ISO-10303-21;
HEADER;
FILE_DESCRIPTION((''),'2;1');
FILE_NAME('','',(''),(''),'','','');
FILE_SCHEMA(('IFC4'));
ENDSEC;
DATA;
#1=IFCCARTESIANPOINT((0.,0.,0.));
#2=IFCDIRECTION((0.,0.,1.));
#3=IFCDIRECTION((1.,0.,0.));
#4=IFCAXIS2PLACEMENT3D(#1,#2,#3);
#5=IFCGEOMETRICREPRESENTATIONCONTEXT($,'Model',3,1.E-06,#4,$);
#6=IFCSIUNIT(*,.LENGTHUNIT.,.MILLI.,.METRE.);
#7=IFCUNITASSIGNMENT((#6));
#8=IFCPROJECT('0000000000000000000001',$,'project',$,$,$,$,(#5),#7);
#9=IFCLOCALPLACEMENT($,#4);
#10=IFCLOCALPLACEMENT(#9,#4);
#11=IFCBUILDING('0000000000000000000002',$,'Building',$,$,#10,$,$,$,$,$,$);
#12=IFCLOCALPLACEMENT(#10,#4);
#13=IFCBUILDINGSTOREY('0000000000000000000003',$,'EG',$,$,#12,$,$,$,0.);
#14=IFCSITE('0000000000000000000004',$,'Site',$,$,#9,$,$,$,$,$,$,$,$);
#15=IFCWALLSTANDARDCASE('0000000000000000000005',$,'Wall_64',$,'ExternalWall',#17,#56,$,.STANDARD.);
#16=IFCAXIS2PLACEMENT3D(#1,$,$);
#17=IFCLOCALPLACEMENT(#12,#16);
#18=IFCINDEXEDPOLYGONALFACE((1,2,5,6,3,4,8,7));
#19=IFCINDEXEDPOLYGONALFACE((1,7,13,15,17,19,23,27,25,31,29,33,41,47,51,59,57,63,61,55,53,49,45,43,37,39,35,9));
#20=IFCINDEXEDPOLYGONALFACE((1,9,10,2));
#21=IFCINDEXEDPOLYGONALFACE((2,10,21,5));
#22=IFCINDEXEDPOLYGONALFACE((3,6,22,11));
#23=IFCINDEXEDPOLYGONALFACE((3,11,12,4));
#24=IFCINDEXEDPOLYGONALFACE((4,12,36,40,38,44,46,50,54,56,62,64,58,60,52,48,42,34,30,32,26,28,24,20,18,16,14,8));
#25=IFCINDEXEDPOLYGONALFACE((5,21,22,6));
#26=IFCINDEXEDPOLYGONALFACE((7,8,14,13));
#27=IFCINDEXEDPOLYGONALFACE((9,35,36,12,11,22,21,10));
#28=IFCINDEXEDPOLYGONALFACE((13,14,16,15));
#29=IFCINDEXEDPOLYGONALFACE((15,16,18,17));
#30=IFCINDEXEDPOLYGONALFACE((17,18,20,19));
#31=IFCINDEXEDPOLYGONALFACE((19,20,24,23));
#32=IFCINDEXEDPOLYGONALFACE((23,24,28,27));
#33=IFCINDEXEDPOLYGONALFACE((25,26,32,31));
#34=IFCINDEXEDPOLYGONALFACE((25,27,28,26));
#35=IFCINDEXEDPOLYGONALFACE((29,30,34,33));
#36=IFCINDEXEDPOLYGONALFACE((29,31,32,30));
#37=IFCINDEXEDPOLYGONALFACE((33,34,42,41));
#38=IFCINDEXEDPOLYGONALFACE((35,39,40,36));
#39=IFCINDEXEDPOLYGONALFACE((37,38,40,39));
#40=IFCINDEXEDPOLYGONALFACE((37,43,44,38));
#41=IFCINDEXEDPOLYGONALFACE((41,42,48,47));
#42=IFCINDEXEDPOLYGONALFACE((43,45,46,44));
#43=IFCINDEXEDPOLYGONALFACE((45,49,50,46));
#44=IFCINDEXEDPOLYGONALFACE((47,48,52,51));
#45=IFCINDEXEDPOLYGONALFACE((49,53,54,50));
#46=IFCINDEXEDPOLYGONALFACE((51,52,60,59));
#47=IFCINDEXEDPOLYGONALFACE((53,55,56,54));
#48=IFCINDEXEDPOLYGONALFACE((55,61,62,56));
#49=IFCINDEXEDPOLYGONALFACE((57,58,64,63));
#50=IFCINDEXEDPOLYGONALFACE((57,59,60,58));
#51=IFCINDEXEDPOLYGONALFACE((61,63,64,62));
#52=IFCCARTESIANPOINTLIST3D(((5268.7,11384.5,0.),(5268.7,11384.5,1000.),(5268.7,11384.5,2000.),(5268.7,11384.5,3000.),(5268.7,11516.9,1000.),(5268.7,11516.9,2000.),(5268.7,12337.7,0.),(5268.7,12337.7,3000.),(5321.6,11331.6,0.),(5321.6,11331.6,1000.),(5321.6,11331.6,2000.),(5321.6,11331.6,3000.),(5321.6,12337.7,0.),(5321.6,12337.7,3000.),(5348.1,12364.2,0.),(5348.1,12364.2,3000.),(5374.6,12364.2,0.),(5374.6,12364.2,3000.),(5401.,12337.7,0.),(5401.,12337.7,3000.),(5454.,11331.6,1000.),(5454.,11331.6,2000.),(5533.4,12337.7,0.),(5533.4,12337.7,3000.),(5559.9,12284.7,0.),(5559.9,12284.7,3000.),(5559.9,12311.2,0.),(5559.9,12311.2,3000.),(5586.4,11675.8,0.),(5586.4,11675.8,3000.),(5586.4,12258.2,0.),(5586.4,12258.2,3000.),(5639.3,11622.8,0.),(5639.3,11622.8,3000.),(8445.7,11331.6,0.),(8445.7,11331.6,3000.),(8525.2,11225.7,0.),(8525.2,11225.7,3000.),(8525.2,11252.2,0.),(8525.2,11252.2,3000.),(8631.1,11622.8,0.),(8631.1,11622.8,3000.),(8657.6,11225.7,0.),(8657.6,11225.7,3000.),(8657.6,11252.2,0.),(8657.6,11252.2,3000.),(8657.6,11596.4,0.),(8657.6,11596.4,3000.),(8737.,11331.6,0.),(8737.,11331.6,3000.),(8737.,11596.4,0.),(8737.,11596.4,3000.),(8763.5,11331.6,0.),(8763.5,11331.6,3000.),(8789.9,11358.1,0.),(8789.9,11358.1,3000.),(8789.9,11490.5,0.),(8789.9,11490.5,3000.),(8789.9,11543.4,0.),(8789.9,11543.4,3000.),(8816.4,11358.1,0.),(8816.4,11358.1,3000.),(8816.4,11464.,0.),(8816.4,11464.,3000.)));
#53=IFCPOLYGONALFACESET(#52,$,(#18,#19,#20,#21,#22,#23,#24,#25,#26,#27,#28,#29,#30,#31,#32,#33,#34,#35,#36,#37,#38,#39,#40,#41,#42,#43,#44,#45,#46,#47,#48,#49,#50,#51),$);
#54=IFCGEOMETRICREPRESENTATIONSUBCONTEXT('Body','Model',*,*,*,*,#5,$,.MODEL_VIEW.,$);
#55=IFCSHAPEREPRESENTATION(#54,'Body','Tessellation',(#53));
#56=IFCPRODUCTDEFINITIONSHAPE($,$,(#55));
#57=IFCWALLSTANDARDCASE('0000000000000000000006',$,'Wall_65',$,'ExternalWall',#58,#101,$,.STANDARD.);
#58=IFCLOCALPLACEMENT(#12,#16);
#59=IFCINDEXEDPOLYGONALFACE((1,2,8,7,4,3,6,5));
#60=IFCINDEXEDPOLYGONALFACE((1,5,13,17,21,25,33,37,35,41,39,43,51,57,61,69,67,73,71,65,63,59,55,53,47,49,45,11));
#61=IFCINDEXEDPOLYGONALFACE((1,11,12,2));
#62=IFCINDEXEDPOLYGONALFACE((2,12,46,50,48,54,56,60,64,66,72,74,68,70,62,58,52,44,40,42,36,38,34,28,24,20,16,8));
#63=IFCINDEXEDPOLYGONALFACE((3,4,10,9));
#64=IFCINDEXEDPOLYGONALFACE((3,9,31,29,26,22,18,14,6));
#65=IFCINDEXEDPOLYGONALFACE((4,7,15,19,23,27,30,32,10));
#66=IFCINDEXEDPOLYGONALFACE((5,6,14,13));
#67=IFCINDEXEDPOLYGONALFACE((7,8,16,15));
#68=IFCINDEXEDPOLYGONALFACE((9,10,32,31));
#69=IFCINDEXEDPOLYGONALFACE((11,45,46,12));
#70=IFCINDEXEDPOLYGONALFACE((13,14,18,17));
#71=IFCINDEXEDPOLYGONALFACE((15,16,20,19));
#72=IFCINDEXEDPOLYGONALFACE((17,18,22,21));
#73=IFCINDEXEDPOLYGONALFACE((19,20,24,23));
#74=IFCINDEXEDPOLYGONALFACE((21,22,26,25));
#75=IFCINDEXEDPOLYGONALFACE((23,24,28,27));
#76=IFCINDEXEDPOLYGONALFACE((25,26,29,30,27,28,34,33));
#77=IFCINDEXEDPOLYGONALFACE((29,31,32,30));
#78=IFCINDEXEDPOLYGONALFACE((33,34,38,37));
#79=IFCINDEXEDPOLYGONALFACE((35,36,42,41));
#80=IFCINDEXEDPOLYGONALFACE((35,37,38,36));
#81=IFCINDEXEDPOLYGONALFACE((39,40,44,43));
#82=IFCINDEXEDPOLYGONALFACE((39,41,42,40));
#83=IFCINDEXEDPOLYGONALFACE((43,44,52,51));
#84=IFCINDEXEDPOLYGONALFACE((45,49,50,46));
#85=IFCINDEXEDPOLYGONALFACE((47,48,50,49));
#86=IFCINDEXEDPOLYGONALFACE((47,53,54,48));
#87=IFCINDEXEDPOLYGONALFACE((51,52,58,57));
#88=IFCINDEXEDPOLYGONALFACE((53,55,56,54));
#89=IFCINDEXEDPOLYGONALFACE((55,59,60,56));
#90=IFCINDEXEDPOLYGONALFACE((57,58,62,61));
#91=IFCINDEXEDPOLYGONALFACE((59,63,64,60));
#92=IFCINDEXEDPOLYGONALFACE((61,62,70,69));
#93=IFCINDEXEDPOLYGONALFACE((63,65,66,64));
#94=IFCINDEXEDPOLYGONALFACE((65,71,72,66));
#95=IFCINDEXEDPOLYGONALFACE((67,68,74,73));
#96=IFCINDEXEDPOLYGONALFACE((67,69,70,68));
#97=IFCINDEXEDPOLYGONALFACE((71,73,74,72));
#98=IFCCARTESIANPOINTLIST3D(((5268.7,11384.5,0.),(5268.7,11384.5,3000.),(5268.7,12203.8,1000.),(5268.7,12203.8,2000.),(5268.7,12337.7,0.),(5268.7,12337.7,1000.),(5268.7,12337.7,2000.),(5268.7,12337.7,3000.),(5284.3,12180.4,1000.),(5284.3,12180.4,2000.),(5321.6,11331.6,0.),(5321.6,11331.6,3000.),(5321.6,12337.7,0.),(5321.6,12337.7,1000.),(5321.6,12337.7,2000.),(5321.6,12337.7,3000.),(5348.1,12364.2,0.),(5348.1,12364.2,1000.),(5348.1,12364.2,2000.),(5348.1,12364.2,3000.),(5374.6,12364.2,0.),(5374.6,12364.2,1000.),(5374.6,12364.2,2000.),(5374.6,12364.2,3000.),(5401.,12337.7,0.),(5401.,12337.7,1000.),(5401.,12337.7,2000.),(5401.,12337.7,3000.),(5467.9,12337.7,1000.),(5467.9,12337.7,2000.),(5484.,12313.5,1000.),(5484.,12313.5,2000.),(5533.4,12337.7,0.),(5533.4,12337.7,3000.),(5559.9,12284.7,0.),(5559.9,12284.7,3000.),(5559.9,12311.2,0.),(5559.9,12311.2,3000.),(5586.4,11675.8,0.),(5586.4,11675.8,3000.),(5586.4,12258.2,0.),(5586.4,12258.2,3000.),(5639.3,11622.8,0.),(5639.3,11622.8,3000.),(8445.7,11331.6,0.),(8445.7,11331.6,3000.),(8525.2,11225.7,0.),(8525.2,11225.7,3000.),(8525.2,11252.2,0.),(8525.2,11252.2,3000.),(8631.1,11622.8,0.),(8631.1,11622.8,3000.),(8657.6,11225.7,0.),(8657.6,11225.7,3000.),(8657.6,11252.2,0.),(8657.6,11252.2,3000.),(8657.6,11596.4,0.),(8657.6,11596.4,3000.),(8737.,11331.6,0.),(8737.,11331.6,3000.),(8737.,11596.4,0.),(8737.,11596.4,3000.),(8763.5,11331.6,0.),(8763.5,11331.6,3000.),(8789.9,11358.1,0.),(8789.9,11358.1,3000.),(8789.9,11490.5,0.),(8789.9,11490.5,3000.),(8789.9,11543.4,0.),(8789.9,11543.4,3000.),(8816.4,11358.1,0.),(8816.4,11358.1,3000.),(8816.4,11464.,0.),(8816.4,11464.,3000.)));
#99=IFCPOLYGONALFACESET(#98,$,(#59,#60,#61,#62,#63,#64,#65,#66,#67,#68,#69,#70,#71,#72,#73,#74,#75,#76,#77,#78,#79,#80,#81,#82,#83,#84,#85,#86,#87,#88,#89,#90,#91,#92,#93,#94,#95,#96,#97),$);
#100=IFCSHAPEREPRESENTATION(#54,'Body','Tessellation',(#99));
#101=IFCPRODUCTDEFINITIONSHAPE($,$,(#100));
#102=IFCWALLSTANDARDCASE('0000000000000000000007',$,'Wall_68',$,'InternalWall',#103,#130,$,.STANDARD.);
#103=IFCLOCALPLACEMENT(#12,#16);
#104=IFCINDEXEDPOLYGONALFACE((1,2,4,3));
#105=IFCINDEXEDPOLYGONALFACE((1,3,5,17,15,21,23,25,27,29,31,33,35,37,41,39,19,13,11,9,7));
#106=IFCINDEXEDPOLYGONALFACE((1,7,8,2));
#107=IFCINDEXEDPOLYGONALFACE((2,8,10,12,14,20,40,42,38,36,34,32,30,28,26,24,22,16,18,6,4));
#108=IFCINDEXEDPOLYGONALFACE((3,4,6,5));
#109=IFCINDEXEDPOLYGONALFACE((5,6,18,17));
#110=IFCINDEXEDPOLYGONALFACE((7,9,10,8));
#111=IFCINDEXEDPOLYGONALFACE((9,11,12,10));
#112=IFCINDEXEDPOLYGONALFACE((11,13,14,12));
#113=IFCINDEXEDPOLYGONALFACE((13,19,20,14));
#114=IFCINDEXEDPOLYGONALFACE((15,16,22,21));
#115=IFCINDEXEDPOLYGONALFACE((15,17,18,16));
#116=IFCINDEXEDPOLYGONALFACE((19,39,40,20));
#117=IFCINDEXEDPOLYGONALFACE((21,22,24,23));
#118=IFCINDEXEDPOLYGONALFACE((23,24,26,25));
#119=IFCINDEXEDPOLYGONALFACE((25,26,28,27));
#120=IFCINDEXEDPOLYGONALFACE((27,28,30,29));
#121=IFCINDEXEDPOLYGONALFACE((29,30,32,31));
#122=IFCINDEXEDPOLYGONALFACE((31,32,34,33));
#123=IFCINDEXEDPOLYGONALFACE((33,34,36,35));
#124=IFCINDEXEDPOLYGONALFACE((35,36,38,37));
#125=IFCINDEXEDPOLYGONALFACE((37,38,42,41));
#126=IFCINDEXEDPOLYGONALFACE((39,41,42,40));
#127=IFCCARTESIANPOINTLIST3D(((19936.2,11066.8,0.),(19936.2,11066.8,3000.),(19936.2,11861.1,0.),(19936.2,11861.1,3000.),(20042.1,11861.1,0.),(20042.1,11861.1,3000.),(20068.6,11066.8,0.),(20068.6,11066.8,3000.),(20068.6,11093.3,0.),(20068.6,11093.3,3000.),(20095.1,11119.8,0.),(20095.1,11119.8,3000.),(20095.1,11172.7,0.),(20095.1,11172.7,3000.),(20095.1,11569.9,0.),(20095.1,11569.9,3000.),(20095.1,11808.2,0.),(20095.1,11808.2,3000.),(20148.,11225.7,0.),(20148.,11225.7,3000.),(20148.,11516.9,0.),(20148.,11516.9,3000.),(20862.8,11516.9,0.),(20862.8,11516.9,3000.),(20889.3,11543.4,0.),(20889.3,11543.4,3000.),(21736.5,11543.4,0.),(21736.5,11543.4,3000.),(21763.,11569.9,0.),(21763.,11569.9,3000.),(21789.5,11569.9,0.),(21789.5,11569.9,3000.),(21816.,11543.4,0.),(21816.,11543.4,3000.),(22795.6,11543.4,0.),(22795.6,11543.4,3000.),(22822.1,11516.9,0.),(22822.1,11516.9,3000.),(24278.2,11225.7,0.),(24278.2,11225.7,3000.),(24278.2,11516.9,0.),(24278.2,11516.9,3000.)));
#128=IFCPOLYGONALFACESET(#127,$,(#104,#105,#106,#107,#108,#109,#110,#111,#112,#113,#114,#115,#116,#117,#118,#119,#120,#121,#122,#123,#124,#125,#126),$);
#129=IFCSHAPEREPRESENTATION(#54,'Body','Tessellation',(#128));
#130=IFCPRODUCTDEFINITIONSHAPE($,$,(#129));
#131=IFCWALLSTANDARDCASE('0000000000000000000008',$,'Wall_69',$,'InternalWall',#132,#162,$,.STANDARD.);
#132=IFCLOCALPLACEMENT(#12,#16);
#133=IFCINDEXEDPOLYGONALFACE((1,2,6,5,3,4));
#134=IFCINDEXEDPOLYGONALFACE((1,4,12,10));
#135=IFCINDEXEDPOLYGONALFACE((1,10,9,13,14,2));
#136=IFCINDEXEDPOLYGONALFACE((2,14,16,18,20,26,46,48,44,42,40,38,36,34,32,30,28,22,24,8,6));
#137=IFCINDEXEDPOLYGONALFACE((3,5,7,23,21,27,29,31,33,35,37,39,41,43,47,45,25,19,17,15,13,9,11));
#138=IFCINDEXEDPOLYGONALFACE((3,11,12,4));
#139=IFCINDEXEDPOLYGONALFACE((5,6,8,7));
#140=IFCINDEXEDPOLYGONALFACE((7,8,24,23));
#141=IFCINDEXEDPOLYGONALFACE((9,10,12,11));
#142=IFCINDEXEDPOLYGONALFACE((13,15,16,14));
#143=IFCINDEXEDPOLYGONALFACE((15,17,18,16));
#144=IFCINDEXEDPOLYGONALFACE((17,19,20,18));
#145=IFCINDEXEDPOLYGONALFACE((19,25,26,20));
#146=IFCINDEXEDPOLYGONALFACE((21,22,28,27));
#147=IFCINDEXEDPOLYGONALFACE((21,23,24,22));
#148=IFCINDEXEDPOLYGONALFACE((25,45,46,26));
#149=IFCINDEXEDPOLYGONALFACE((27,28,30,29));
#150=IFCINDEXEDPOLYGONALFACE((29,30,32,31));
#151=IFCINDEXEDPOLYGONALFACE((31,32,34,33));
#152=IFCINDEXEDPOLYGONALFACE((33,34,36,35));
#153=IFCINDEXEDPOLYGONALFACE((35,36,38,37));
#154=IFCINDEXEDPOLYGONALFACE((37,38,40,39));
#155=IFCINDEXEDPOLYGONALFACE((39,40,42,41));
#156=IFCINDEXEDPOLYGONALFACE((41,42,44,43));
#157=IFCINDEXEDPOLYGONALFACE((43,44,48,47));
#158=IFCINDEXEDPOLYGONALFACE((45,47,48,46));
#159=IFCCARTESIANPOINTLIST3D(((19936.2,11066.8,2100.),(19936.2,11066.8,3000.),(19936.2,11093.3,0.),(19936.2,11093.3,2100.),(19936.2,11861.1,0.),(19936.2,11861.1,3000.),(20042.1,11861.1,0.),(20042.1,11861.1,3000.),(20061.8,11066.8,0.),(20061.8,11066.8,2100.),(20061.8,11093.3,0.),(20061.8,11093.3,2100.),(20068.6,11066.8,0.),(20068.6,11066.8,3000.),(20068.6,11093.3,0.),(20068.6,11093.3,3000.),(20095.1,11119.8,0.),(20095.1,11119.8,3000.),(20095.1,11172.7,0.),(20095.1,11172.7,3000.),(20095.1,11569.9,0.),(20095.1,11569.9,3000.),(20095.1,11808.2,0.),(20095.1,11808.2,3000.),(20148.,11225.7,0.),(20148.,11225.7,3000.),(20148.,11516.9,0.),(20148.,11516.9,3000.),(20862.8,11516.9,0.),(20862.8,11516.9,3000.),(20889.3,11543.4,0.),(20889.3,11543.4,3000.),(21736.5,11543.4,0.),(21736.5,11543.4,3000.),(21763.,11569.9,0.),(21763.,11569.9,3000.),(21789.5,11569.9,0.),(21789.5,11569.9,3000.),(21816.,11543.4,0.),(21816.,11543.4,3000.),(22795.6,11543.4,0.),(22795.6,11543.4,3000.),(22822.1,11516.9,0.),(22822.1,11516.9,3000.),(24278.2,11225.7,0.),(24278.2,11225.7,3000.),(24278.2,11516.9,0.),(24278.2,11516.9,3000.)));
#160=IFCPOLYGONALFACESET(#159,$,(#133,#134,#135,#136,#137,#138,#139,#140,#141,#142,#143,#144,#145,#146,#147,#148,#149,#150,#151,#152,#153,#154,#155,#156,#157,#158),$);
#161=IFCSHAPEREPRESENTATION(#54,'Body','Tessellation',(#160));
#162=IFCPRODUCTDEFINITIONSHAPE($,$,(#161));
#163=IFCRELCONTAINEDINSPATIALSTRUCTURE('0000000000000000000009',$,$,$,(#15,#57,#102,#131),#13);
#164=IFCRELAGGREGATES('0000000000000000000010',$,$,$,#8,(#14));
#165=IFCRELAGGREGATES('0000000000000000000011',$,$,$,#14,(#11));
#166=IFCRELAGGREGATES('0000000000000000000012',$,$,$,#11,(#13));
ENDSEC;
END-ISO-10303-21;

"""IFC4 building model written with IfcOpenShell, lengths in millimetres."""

from ifc_helpers import new_model, si_unit, frame, origin_with_axes, place, context, subcontext, project, spatial, polyline, rectangle, outline, extrude, element, save


model = new_model("IFC4")

# Units and contexts
model_context = context("Model", 3, precision=1e-06, world=origin_with_axes())
body_context = subcontext(model_context, "Body", "Model", "MODEL_VIEW")
ifc_project = project(units=[si_unit("LENGTHUNIT", "METRE", prefix="MILLI")], contexts=[model_context])

# Site, building, storey
site_placement = place(None, origin_with_axes())
site = spatial("IfcSite", under=ifc_project, at=site_placement, Name="Site")
building_placement = place(site_placement, origin_with_axes())
building = spatial("IfcBuilding", under=site, at=building_placement, Name="Building")
storey_placement = place(building_placement, origin_with_axes())
storey = spatial("IfcBuildingStorey", under=building, at=storey_placement, Name="EG", Elevation=0.0)

# Walls, openings
wall_1_placement = place(storey_placement, origin_with_axes())
wall_1 = element("IfcWallStandardCase", 1, at=wall_1_placement, inside=storey, Name="Wall_64", ObjectType="ExternalWall", PredefinedType="STANDARD", context=body_context, shape_type="SweptSolid", body=[
    extrude(outline(polyline([(8525.2, 11225.7, 0.0), (8525.2, 11252.2, 0.0), (8445.7, 11331.6, 0.0), (5321.6, 11331.6, 0.0), (5268.7, 11384.5, 0.0), (5268.7, 12337.7, 0.0), (5321.6, 12337.7, 0.0), (5348.1, 12364.2, 0.0), (5374.6, 12364.2, 0.0), (5401.0, 12337.7, 0.0), (5533.4, 12337.7, 0.0), (5559.9, 12311.2, 0.0), (5559.9, 12284.7, 0.0), (5586.4, 12258.2, 0.0), (5586.4, 11675.8, 0.0), (5639.3, 11622.8, 0.0), (8631.1, 11622.8, 0.0), (8657.6, 11596.4, 0.0), (8737.0, 11596.4, 0.0), (8789.9, 11543.4, 0.0), (8789.9, 11490.5, 0.0), (8816.4, 11464.0, 0.0), (8816.4, 11358.1, 0.0), (8789.9, 11358.1, 0.0), (8763.5, 11331.6, 0.0), (8737.0, 11331.6, 0.0), (8657.6, 11252.2, 0.0), (8657.6, 11225.7, 0.0), (8525.2, 11225.7, 0.0)])), origin_with_axes(), (0.0, 0.0, 1.0), 3000.0),
])
opening_1_placement = place(wall_1_placement, origin_with_axes())
element("IfcOpeningElement", 2, at=opening_1_placement, inside=storey, cuts=wall_1, context=body_context, shape_type="SweptSolid", body=[
    extrude(rectangle(XDim=636.5, YDim=300.0), frame((5133.7, 11201.8, 1000.0), z_axis=(0.0, 0.0, 1.0), x_axis=(-0.707107, -0.707107, 0.0)), (0.0, 0.0, 1.0), 1000.0),
])
wall_2_placement = place(storey_placement, origin_with_axes())
wall_2 = element("IfcWallStandardCase", 3, at=wall_2_placement, inside=storey, Name="Wall_65", ObjectType="ExternalWall", PredefinedType="STANDARD", context=body_context, shape_type="SweptSolid", body=[
    extrude(outline(polyline([(8525.2, 11225.7, 0.0), (8525.2, 11252.2, 0.0), (8445.7, 11331.6, 0.0), (5321.6, 11331.6, 0.0), (5268.7, 11384.5, 0.0), (5268.7, 12337.7, 0.0), (5321.6, 12337.7, 0.0), (5348.1, 12364.2, 0.0), (5374.6, 12364.2, 0.0), (5401.0, 12337.7, 0.0), (5533.4, 12337.7, 0.0), (5559.9, 12311.2, 0.0), (5559.9, 12284.7, 0.0), (5586.4, 12258.2, 0.0), (5586.4, 11675.8, 0.0), (5639.3, 11622.8, 0.0), (8631.1, 11622.8, 0.0), (8657.6, 11596.4, 0.0), (8737.0, 11596.4, 0.0), (8789.9, 11543.4, 0.0), (8789.9, 11490.5, 0.0), (8816.4, 11464.0, 0.0), (8816.4, 11358.1, 0.0), (8789.9, 11358.1, 0.0), (8763.5, 11331.6, 0.0), (8737.0, 11331.6, 0.0), (8657.6, 11252.2, 0.0), (8657.6, 11225.7, 0.0), (8525.2, 11225.7, 0.0)])), origin_with_axes(), (0.0, 0.0, 1.0), 3000.0),
])
opening_2_placement = place(wall_2_placement, origin_with_axes())
element("IfcOpeningElement", 4, at=opening_2_placement, inside=storey, cuts=wall_2, context=body_context, shape_type="SweptSolid", body=[
    extrude(rectangle(XDim=2592.1, YDim=240.0), frame((4665.2, 13325.3, 1000.0), z_axis=(0.0, 0.0, 1.0), x_axis=(-0.5547, 0.83205, 0.0)), (0.0, 0.0, 1.0), 1000.0),
])

# Wall
wall_3_placement = place(storey_placement, origin_with_axes())
element("IfcWallStandardCase", 5, at=wall_3_placement, inside=storey, Name="Wall_68", ObjectType="InternalWall", PredefinedType="STANDARD", context=body_context, shape_type="SweptSolid", body=[
    extrude(outline(polyline([(19936.2, 11066.8, 0.0), (19936.2, 11861.1, 0.0), (20042.1, 11861.1, 0.0), (20095.1, 11808.2, 0.0), (20095.1, 11569.9, 0.0), (20148.0, 11516.9, 0.0), (20862.8, 11516.9, 0.0), (20889.3, 11543.4, 0.0), (21736.5, 11543.4, 0.0), (21763.0, 11569.9, 0.0), (21789.5, 11569.9, 0.0), (21816.0, 11543.4, 0.0), (22795.6, 11543.4, 0.0), (22822.1, 11516.9, 0.0), (24278.2, 11516.9, 0.0), (24278.2, 11225.7, 0.0), (20148.0, 11225.7, 0.0), (20095.1, 11172.7, 0.0), (20095.1, 11119.8, 0.0), (20068.6, 11093.3, 0.0), (20068.6, 11066.8, 0.0), (19936.2, 11066.8, 0.0)])), origin_with_axes(), (0.0, 0.0, 1.0), 3000.0),
])

# Wall, openings
wall_4_placement = place(storey_placement, origin_with_axes())
wall_4 = element("IfcWallStandardCase", 6, at=wall_4_placement, inside=storey, Name="Wall_69", ObjectType="InternalWall", PredefinedType="STANDARD", context=body_context, shape_type="SweptSolid", body=[
    extrude(outline(polyline([(19936.2, 11066.8, 0.0), (19936.2, 11861.1, 0.0), (20042.1, 11861.1, 0.0), (20095.1, 11808.2, 0.0), (20095.1, 11569.9, 0.0), (20148.0, 11516.9, 0.0), (20862.8, 11516.9, 0.0), (20889.3, 11543.4, 0.0), (21736.5, 11543.4, 0.0), (21763.0, 11569.9, 0.0), (21789.5, 11569.9, 0.0), (21816.0, 11543.4, 0.0), (22795.6, 11543.4, 0.0), (22822.1, 11516.9, 0.0), (24278.2, 11516.9, 0.0), (24278.2, 11225.7, 0.0), (20148.0, 11225.7, 0.0), (20095.1, 11172.7, 0.0), (20095.1, 11119.8, 0.0), (20068.6, 11093.3, 0.0), (20068.6, 11066.8, 0.0), (19936.2, 11066.8, 0.0)])), origin_with_axes(), (0.0, 0.0, 1.0), 3000.0),
])
opening_3_placement = place(wall_4_placement, origin_with_axes())
element("IfcOpeningElement", 7, at=opening_3_placement, inside=storey, cuts=wall_4, context=body_context, shape_type="SweptSolid", body=[
    extrude(rectangle(XDim=1059.0, YDim=240.0), frame((19941.8, 10563.8, 0.0), z_axis=(0.0, 0.0, 1.0), x_axis=(0.0, -1.0, 0.0)), (0.0, 0.0, 1.0), 2100.0),
])
opening_4_placement = place(wall_4_placement, origin_with_axes())
element("IfcOpeningElement", 8, at=opening_4_placement, inside=storey, cuts=wall_4, context=body_context, shape_type="SweptSolid", body=[
    extrude(rectangle(XDim=847.2, YDim=240.0), frame((19941.8, 12284.7, 0.0), z_axis=(0.0, 0.0, 1.0), x_axis=(0.0, -1.0, 0.0)), (0.0, 0.0, 1.0), 2100.0),
])

save(model, "model.ifc")
